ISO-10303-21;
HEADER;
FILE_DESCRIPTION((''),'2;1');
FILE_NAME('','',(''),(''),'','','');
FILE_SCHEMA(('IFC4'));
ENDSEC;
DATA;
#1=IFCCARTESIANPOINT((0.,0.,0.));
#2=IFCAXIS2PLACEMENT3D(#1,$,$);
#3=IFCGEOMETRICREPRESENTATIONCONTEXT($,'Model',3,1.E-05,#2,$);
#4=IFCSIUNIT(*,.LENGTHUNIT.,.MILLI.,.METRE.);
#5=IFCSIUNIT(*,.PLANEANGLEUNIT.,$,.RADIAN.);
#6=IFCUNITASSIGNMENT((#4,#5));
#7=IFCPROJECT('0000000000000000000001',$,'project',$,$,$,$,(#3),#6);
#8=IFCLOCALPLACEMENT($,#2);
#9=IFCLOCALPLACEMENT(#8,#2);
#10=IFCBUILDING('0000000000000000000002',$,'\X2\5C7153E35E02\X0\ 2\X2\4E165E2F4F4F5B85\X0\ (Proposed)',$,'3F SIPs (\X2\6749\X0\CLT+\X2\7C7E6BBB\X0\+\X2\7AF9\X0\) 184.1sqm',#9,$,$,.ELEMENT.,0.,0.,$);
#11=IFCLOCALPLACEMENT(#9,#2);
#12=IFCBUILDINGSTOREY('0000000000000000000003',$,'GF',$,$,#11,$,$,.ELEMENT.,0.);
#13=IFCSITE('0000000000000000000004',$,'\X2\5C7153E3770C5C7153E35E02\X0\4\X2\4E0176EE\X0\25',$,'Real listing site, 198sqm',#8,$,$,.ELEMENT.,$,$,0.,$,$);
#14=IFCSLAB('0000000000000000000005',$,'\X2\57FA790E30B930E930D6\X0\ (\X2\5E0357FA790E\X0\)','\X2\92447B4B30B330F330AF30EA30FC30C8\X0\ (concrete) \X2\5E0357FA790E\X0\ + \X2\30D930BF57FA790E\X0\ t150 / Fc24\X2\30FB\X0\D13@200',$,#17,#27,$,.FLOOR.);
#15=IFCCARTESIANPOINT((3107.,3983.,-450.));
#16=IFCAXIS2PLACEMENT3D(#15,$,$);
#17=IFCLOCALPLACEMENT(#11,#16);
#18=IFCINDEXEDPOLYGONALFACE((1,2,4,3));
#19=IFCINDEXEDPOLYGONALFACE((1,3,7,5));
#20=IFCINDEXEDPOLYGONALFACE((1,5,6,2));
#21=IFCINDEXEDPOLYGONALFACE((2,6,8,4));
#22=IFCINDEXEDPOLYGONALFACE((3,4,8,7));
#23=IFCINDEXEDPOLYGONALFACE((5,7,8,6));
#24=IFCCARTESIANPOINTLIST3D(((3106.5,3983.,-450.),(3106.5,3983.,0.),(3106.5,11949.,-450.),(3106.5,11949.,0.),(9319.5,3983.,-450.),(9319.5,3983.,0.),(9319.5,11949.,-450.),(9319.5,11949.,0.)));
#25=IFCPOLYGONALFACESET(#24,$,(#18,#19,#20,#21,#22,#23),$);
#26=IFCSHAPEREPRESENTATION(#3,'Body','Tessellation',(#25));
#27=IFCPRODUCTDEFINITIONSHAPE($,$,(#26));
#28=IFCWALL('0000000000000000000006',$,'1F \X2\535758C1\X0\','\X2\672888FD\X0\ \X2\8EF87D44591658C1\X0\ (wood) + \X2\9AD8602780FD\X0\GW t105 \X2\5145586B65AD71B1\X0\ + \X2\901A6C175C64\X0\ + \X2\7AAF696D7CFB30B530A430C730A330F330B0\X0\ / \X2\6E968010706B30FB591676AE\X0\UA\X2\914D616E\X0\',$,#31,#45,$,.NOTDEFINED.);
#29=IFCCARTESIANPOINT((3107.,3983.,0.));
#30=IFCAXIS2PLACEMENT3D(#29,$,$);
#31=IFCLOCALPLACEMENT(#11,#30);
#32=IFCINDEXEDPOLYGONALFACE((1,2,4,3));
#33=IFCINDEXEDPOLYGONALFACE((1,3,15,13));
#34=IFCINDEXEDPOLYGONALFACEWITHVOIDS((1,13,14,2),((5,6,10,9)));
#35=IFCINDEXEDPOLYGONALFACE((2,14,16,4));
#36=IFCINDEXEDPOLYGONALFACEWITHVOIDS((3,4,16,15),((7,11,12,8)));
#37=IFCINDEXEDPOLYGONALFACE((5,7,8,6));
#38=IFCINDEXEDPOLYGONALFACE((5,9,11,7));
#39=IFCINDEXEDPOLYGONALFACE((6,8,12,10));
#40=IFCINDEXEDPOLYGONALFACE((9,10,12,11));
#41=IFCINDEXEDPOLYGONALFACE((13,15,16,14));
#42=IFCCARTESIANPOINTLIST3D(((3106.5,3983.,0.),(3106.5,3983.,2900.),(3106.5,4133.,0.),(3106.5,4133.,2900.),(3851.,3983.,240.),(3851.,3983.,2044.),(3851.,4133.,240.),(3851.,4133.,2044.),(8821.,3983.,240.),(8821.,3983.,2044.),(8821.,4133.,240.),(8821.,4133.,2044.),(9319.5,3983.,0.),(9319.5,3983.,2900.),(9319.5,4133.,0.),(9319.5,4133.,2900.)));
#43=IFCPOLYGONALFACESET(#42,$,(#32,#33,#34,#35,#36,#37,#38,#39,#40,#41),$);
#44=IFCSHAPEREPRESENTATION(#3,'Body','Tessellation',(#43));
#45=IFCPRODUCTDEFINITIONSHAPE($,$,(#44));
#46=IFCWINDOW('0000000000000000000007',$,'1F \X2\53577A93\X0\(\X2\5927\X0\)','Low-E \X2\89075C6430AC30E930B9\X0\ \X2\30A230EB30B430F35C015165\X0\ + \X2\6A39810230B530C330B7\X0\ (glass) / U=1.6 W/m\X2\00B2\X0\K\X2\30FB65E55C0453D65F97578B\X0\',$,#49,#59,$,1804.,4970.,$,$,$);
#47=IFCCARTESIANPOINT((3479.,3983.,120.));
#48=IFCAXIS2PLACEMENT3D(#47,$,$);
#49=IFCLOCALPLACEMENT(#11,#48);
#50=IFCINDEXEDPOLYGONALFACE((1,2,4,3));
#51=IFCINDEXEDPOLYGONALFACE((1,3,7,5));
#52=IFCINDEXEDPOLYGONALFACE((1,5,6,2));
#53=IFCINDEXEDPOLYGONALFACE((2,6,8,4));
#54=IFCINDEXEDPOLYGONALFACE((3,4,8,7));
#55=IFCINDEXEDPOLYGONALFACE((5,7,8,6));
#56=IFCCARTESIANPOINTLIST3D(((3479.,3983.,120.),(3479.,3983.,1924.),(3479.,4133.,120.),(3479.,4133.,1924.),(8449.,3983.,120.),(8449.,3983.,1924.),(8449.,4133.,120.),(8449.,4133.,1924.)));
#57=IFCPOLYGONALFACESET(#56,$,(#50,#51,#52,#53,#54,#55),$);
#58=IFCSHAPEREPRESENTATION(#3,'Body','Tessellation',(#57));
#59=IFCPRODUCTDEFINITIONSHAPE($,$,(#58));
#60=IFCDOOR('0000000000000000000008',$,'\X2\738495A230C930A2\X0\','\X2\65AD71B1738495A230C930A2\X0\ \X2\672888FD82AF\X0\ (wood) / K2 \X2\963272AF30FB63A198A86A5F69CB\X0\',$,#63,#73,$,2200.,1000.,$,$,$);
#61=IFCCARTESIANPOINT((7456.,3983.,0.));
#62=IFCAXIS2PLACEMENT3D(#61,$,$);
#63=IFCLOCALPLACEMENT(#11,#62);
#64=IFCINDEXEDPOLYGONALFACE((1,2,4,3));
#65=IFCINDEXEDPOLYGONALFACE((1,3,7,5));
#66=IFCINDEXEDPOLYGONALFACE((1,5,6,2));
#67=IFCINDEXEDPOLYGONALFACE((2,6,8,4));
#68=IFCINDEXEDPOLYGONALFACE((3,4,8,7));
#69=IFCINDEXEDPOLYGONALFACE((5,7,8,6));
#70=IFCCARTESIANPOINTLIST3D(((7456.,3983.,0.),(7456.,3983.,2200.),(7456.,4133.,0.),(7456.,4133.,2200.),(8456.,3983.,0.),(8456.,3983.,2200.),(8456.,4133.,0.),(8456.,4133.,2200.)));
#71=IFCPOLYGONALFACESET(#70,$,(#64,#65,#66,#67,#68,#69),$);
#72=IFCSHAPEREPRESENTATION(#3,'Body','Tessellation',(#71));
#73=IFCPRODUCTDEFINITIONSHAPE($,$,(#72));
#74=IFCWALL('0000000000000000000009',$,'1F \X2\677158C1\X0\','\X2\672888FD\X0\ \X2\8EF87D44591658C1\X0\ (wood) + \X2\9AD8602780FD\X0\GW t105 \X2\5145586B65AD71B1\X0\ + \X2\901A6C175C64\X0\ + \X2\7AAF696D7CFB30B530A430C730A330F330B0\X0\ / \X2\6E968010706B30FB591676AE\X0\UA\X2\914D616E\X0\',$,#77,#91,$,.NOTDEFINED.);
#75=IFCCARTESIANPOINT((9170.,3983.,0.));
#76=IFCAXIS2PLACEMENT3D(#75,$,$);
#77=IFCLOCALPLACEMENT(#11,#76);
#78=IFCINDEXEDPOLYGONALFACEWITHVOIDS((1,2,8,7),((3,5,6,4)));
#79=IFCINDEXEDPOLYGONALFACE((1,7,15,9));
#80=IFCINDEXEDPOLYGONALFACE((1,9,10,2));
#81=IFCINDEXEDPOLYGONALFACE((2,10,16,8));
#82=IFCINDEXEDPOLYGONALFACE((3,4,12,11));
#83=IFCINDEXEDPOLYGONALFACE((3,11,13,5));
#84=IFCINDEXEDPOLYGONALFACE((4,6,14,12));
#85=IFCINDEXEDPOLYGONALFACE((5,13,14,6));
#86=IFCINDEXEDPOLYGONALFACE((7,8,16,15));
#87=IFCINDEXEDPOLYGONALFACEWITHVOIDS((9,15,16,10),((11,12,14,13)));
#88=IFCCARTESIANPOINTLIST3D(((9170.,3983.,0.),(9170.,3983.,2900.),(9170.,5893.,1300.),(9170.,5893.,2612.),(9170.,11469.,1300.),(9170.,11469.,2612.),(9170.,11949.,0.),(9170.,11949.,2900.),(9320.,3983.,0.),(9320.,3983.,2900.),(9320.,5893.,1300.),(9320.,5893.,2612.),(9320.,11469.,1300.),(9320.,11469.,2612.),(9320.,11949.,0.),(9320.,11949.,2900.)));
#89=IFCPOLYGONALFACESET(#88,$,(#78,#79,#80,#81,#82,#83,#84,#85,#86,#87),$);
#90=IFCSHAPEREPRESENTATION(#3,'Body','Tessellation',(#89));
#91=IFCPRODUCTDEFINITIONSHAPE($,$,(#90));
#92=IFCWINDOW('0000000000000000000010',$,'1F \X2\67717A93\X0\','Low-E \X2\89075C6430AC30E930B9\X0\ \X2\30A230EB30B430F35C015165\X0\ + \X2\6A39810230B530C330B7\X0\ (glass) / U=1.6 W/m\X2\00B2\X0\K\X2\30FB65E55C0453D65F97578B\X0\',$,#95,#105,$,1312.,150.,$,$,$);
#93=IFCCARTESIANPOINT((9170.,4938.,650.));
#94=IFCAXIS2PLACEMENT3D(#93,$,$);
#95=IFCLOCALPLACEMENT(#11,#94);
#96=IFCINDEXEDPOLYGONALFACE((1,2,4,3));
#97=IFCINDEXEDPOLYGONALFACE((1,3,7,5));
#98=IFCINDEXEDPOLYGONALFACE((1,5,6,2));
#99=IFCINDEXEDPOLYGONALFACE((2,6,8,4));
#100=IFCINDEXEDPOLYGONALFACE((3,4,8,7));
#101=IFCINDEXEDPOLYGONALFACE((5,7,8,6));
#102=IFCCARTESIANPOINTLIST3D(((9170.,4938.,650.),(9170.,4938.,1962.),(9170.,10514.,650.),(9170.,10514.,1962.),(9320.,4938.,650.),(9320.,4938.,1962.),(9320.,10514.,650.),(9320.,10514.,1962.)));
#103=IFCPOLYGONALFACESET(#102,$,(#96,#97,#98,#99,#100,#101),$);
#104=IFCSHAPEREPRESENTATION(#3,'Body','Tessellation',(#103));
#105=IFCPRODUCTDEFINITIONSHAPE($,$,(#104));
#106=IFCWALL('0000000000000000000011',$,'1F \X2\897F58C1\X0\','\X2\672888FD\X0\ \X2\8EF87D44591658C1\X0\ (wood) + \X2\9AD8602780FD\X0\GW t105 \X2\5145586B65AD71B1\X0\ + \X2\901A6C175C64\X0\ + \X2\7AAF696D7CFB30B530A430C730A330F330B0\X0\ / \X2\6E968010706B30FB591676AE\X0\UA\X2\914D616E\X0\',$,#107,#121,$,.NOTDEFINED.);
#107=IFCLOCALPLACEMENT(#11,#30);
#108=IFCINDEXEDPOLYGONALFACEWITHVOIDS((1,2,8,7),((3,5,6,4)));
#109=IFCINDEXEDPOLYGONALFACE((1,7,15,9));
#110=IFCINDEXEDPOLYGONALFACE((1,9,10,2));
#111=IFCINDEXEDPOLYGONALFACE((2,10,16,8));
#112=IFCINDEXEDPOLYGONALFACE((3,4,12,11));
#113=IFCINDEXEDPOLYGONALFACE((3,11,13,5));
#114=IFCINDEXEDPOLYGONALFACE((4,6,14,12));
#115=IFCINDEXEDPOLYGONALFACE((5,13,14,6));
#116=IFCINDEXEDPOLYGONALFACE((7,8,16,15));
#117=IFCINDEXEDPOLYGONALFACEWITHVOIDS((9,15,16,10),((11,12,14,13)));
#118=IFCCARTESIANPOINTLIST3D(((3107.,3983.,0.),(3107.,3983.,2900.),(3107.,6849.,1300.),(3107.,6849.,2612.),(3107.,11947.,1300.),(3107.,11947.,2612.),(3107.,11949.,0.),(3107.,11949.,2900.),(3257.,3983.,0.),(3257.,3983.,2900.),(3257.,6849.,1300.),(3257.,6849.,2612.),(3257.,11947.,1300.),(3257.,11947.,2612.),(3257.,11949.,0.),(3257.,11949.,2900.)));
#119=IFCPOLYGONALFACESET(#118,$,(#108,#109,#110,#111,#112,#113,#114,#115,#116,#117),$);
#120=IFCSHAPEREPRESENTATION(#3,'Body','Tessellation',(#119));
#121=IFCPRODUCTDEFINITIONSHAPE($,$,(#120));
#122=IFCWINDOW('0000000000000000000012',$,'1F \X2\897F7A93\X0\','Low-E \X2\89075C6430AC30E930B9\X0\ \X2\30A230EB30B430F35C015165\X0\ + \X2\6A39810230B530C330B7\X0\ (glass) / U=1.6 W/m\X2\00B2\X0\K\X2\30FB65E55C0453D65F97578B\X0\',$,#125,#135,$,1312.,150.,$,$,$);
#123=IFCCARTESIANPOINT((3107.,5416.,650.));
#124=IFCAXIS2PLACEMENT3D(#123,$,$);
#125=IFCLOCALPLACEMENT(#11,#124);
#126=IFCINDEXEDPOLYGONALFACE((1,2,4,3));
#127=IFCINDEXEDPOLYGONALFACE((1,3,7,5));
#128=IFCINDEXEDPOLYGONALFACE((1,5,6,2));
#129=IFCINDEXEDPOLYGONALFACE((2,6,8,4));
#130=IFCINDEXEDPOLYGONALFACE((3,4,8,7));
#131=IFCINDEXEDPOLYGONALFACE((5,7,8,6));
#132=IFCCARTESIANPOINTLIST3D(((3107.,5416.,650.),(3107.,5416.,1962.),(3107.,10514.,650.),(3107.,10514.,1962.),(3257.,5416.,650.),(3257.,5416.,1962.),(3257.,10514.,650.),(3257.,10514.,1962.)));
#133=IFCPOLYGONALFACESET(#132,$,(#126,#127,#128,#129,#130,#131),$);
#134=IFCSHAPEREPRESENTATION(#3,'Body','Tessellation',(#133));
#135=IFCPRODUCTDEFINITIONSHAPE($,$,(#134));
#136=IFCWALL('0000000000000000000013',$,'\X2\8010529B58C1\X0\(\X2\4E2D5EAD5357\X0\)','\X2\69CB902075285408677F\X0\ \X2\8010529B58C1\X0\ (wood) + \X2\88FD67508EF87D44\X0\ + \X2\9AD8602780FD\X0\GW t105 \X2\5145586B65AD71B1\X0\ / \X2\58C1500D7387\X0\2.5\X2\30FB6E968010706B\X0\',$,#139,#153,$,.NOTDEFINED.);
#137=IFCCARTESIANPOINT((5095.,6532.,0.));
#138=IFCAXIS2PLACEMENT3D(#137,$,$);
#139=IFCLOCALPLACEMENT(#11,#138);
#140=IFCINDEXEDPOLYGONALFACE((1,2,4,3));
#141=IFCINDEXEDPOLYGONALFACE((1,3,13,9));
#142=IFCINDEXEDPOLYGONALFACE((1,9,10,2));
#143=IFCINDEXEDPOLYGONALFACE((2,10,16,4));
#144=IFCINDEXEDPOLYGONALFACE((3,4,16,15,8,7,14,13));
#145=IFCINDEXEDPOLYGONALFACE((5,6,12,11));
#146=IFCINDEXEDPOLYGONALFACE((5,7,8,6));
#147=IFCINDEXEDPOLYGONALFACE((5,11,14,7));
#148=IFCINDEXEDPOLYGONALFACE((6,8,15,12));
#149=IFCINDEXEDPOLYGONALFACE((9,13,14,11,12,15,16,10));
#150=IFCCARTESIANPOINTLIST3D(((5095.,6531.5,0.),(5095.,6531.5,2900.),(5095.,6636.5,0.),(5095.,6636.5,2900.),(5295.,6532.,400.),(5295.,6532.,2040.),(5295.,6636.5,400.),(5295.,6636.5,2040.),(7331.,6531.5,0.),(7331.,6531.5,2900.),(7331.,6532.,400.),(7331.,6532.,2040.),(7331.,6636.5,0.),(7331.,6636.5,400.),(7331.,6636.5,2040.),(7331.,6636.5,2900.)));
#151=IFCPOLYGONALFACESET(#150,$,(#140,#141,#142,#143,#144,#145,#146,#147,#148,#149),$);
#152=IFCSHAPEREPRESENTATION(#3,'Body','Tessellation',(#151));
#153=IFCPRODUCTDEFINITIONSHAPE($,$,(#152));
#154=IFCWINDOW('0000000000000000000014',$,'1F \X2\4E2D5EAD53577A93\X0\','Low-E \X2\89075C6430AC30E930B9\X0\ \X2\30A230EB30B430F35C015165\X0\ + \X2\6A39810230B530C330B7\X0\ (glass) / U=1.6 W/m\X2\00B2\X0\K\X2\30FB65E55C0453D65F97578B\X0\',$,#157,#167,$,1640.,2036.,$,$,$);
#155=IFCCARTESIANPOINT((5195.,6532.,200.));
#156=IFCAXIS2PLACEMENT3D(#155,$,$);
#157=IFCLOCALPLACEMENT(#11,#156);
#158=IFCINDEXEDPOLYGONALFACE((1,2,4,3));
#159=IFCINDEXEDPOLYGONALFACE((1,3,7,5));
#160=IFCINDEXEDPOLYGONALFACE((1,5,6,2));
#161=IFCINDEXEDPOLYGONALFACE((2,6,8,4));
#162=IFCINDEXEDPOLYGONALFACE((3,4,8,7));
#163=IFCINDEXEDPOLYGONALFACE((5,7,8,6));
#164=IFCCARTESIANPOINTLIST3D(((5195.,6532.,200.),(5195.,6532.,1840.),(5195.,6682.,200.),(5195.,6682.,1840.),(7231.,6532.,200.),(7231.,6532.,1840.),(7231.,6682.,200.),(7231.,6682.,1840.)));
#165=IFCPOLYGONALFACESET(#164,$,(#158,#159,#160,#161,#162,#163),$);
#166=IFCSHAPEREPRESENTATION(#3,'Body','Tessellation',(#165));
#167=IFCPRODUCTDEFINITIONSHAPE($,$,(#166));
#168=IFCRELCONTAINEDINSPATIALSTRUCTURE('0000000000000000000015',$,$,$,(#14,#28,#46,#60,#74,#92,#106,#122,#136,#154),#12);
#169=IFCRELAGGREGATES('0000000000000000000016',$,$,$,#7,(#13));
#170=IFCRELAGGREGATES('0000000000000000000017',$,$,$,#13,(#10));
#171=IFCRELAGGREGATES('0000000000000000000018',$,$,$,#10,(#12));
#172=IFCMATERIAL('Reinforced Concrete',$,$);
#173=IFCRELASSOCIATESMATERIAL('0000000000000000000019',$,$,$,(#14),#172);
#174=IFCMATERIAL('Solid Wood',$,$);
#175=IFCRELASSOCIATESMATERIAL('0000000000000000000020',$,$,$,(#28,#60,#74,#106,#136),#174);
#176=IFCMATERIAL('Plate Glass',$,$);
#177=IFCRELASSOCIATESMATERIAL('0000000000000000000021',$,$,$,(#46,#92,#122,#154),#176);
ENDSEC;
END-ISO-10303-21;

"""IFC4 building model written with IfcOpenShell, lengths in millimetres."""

from ifc_helpers import new_model, si_unit, frame, frame_2d, origin, place, context, project, spatial, rectangle, extrude, material, element, fill, save


model = new_model("IFC4")

# Units and contexts
model_context = context("Model", 3, precision=1e-05, world=origin())
ifc_project = project(units=[si_unit("LENGTHUNIT", "METRE", prefix="MILLI"), si_unit("PLANEANGLEUNIT", "RADIAN")], contexts=[model_context])

# Site, building, storey
site_placement = place(None, origin())
site = spatial("IfcSite", under=ifc_project, at=site_placement, Name="山口県山口市4丁目25", ObjectType="Real listing site, 198sqm", CompositionType="ELEMENT", RefElevation=0.0)
building_placement = place(site_placement, origin())
building = spatial("IfcBuilding", under=site, at=building_placement, Name="山口市 2世帯住宅 (Proposed)", ObjectType="3F SIPs (杉CLT+籾殻+竹) 184.1sqm", CompositionType="ELEMENT", ElevationOfRefHeight=0.0, ElevationOfTerrain=0.0)
storey_placement = place(building_placement, origin())
storey = spatial("IfcBuildingStorey", under=building, at=storey_placement, Name="GF", CompositionType="ELEMENT", Elevation=0.0)

# Slab
ifc_material_1 = material(Name="Reinforced Concrete")
slab_1_placement = place(storey_placement, frame((3107.0, 3983.0, -450.0)))
element("IfcSlab", 1, at=slab_1_placement, inside=storey, material=ifc_material_1, Name="基礎スラブ (布基礎)", Description="鉄筋コンクリート (concrete) 布基礎 + ベタ基礎 t150 / Fc24・D13@200", PredefinedType="FLOOR", context=model_context, shape_type="SweptSolid", body=[
    extrude(rectangle(XDim=6213.0, YDim=7966.0, at=frame_2d((3106.0, 3983.0))), frame((3107.0, 3983.0, -450.0)), (0.0, 0.0, 1.0), 450.0),
])
ifc_material_2 = material(Name="Solid Wood")

# Wall, openings, window, door
wall_1_placement = place(storey_placement, frame((3107.0, 3983.0, 0.0)))
wall_1 = element("IfcWall", 2, at=wall_1_placement, inside=storey, material=ifc_material_2, Name="1F 南壁", Description="木製 軸組外壁 (wood) + 高性能GW t105 充填断熱 + 通気層 + 窯業系サイディング / 準耐火・外皮UA配慮", PredefinedType="NOTDEFINED", context=model_context, shape_type="SweptSolid", body=[
    extrude(rectangle(XDim=6213.0, YDim=150.0, at=frame_2d((3106.0, 75.0))), frame((3107.0, 3983.0, 0.0)), (0.0, 0.0, 1.0), 2900.0),
])
opening_1_placement = place(storey_placement, frame((3479.0, 3983.0, 120.0)))
opening_1 = element("IfcOpeningElement", 3, at=opening_1_placement, cuts=wall_1, PredefinedType="NOTDEFINED", context=model_context, shape_type="SweptSolid", body=[
    extrude(rectangle(XDim=4970.0, YDim=150.0, at=frame_2d((2485.0, 75.0))), frame((3479.0, 3983.0, 120.0)), (0.0, 0.0, 1.0), 1804.0),
])
opening_2_placement = place(storey_placement, frame((7456.0, 3983.0, 0.0)))
opening_2 = element("IfcOpeningElement", 4, at=opening_2_placement, cuts=wall_1, PredefinedType="NOTDEFINED", context=model_context, shape_type="SweptSolid", body=[
    extrude(rectangle(XDim=1000.0, YDim=150.0, at=frame_2d((500.0, 75.0))), frame((7456.0, 3983.0, 0.0)), (0.0, 0.0, 1.0), 2200.0),
])
ifc_material_3 = material(Name="Plate Glass")
window_1_placement = place(storey_placement, frame((3479.0, 3983.0, 120.0)))
window_1 = element("IfcWindow", 5, at=window_1_placement, inside=storey, material=ifc_material_3, Name="1F 南窓(大)", Description="Low-E 複層ガラス アルゴン封入 + 樹脂サッシ (glass) / U=1.6 W/m²K・日射取得型", OverallHeight=1804.0, OverallWidth=4970.0, context=model_context, shape_type="SweptSolid", body=[
    extrude(rectangle(XDim=4970.0, YDim=150.0, at=frame_2d((2485.0, 75.0))), frame((3479.0, 3983.0, 120.0)), (0.0, 0.0, 1.0), 1804.0),
])
fill(opening_1, window_1)
door_placement = place(storey_placement, frame((7456.0, 3983.0, 0.0)))
door = element("IfcDoor", 6, at=door_placement, inside=storey, material=ifc_material_2, Name="玄関ドア", Description="断熱玄関ドア 木製芯 (wood) / K2 防犯・採風機構", OverallHeight=2200.0, OverallWidth=1000.0, context=model_context, shape_type="SweptSolid", body=[
    extrude(rectangle(XDim=1000.0, YDim=150.0, at=frame_2d((500.0, 75.0))), frame((7456.0, 3983.0, 0.0)), (0.0, 0.0, 1.0), 2200.0),
])
fill(opening_2, door)

# Walls, openings, windows
wall_2_placement = place(storey_placement, frame((9170.0, 3983.0, 0.0)))
wall_2 = element("IfcWall", 7, at=wall_2_placement, inside=storey, material=ifc_material_2, Name="1F 東壁", Description="木製 軸組外壁 (wood) + 高性能GW t105 充填断熱 + 通気層 + 窯業系サイディング / 準耐火・外皮UA配慮", PredefinedType="NOTDEFINED", context=model_context, shape_type="SweptSolid", body=[
    extrude(rectangle(XDim=150.0, YDim=7966.0, at=frame_2d((75.0, 3983.0))), frame((9170.0, 3983.0, 0.0)), (0.0, 0.0, 1.0), 2900.0),
])
opening_3_placement = place(storey_placement, frame((9170.0, 4938.0, 650.0)))
opening_3 = element("IfcOpeningElement", 8, at=opening_3_placement, cuts=wall_2, PredefinedType="NOTDEFINED", context=model_context, shape_type="SweptSolid", body=[
    extrude(rectangle(XDim=150.0, YDim=5576.0, at=frame_2d((75.0, 2788.0))), frame((9170.0, 4938.0, 650.0)), (0.0, 0.0, 1.0), 1312.0),
])
window_2_placement = place(storey_placement, frame((9170.0, 4938.0, 650.0)))
window_2 = element("IfcWindow", 9, at=window_2_placement, inside=storey, material=ifc_material_3, Name="1F 東窓", Description="Low-E 複層ガラス アルゴン封入 + 樹脂サッシ (glass) / U=1.6 W/m²K・日射取得型", OverallHeight=1312.0, OverallWidth=150.0, context=model_context, shape_type="SweptSolid", body=[
    extrude(rectangle(XDim=150.0, YDim=5576.0, at=frame_2d((75.0, 2788.0))), frame((9170.0, 4938.0, 650.0)), (0.0, 0.0, 1.0), 1312.0),
])
fill(opening_3, window_2)
wall_3_placement = place(storey_placement, frame((3107.0, 3983.0, 0.0)))
wall_3 = element("IfcWall", 10, at=wall_3_placement, inside=storey, material=ifc_material_2, Name="1F 西壁", Description="木製 軸組外壁 (wood) + 高性能GW t105 充填断熱 + 通気層 + 窯業系サイディング / 準耐火・外皮UA配慮", PredefinedType="NOTDEFINED", context=model_context, shape_type="SweptSolid", body=[
    extrude(rectangle(XDim=150.0, YDim=7966.0, at=frame_2d((75.0, 3983.0))), frame((3107.0, 3983.0, 0.0)), (0.0, 0.0, 1.0), 2900.0),
])
opening_4_placement = place(storey_placement, frame((3107.0, 5416.0, 650.0)))
opening_4 = element("IfcOpeningElement", 11, at=opening_4_placement, cuts=wall_3, PredefinedType="NOTDEFINED", context=model_context, shape_type="SweptSolid", body=[
    extrude(rectangle(XDim=150.0, YDim=5098.0, at=frame_2d((75.0, 2549.0))), frame((3107.0, 5416.0, 650.0)), (0.0, 0.0, 1.0), 1312.0),
])
window_3_placement = place(storey_placement, frame((3107.0, 5416.0, 650.0)))
window_3 = element("IfcWindow", 12, at=window_3_placement, inside=storey, material=ifc_material_3, Name="1F 西窓", Description="Low-E 複層ガラス アルゴン封入 + 樹脂サッシ (glass) / U=1.6 W/m²K・日射取得型", OverallHeight=1312.0, OverallWidth=150.0, context=model_context, shape_type="SweptSolid", body=[
    extrude(rectangle(XDim=150.0, YDim=5098.0, at=frame_2d((75.0, 2549.0))), frame((3107.0, 5416.0, 650.0)), (0.0, 0.0, 1.0), 1312.0),
])
fill(opening_4, window_3)
wall_4_placement = place(storey_placement, frame((5095.0, 6532.0, 0.0)))
wall_4 = element("IfcWall", 13, at=wall_4_placement, inside=storey, material=ifc_material_2, Name="耐力壁(中庭南)", Description="構造用合板 耐力壁 (wood) + 製材軸組 + 高性能GW t105 充填断熱 / 壁倍率2.5・準耐火", PredefinedType="NOTDEFINED", context=model_context, shape_type="SweptSolid", body=[
    extrude(rectangle(XDim=2236.0, YDim=105.0, at=frame_2d((1118.0, 52.0))), frame((5095.0, 6532.0, 0.0)), (0.0, 0.0, 1.0), 2900.0),
])
opening_5_placement = place(storey_placement, frame((5195.0, 6532.0, 200.0)))
opening_5 = element("IfcOpeningElement", 14, at=opening_5_placement, cuts=wall_4, PredefinedType="NOTDEFINED", context=model_context, shape_type="SweptSolid", body=[
    extrude(rectangle(XDim=2036.0, YDim=150.0, at=frame_2d((1018.0, 75.0))), frame((5195.0, 6532.0, 200.0)), (0.0, 0.0, 1.0), 1640.0),
])
window_4_placement = place(storey_placement, frame((5195.0, 6532.0, 200.0)))
window_4 = element("IfcWindow", 15, at=window_4_placement, inside=storey, material=ifc_material_3, Name="1F 中庭南窓", Description="Low-E 複層ガラス アルゴン封入 + 樹脂サッシ (glass) / U=1.6 W/m²K・日射取得型", OverallHeight=1640.0, OverallWidth=2036.0, context=model_context, shape_type="SweptSolid", body=[
    extrude(rectangle(XDim=2036.0, YDim=150.0, at=frame_2d((1018.0, 75.0))), frame((5195.0, 6532.0, 200.0)), (0.0, 0.0, 1.0), 1640.0),
])
fill(opening_5, window_4)

save(model, "model.ifc")
